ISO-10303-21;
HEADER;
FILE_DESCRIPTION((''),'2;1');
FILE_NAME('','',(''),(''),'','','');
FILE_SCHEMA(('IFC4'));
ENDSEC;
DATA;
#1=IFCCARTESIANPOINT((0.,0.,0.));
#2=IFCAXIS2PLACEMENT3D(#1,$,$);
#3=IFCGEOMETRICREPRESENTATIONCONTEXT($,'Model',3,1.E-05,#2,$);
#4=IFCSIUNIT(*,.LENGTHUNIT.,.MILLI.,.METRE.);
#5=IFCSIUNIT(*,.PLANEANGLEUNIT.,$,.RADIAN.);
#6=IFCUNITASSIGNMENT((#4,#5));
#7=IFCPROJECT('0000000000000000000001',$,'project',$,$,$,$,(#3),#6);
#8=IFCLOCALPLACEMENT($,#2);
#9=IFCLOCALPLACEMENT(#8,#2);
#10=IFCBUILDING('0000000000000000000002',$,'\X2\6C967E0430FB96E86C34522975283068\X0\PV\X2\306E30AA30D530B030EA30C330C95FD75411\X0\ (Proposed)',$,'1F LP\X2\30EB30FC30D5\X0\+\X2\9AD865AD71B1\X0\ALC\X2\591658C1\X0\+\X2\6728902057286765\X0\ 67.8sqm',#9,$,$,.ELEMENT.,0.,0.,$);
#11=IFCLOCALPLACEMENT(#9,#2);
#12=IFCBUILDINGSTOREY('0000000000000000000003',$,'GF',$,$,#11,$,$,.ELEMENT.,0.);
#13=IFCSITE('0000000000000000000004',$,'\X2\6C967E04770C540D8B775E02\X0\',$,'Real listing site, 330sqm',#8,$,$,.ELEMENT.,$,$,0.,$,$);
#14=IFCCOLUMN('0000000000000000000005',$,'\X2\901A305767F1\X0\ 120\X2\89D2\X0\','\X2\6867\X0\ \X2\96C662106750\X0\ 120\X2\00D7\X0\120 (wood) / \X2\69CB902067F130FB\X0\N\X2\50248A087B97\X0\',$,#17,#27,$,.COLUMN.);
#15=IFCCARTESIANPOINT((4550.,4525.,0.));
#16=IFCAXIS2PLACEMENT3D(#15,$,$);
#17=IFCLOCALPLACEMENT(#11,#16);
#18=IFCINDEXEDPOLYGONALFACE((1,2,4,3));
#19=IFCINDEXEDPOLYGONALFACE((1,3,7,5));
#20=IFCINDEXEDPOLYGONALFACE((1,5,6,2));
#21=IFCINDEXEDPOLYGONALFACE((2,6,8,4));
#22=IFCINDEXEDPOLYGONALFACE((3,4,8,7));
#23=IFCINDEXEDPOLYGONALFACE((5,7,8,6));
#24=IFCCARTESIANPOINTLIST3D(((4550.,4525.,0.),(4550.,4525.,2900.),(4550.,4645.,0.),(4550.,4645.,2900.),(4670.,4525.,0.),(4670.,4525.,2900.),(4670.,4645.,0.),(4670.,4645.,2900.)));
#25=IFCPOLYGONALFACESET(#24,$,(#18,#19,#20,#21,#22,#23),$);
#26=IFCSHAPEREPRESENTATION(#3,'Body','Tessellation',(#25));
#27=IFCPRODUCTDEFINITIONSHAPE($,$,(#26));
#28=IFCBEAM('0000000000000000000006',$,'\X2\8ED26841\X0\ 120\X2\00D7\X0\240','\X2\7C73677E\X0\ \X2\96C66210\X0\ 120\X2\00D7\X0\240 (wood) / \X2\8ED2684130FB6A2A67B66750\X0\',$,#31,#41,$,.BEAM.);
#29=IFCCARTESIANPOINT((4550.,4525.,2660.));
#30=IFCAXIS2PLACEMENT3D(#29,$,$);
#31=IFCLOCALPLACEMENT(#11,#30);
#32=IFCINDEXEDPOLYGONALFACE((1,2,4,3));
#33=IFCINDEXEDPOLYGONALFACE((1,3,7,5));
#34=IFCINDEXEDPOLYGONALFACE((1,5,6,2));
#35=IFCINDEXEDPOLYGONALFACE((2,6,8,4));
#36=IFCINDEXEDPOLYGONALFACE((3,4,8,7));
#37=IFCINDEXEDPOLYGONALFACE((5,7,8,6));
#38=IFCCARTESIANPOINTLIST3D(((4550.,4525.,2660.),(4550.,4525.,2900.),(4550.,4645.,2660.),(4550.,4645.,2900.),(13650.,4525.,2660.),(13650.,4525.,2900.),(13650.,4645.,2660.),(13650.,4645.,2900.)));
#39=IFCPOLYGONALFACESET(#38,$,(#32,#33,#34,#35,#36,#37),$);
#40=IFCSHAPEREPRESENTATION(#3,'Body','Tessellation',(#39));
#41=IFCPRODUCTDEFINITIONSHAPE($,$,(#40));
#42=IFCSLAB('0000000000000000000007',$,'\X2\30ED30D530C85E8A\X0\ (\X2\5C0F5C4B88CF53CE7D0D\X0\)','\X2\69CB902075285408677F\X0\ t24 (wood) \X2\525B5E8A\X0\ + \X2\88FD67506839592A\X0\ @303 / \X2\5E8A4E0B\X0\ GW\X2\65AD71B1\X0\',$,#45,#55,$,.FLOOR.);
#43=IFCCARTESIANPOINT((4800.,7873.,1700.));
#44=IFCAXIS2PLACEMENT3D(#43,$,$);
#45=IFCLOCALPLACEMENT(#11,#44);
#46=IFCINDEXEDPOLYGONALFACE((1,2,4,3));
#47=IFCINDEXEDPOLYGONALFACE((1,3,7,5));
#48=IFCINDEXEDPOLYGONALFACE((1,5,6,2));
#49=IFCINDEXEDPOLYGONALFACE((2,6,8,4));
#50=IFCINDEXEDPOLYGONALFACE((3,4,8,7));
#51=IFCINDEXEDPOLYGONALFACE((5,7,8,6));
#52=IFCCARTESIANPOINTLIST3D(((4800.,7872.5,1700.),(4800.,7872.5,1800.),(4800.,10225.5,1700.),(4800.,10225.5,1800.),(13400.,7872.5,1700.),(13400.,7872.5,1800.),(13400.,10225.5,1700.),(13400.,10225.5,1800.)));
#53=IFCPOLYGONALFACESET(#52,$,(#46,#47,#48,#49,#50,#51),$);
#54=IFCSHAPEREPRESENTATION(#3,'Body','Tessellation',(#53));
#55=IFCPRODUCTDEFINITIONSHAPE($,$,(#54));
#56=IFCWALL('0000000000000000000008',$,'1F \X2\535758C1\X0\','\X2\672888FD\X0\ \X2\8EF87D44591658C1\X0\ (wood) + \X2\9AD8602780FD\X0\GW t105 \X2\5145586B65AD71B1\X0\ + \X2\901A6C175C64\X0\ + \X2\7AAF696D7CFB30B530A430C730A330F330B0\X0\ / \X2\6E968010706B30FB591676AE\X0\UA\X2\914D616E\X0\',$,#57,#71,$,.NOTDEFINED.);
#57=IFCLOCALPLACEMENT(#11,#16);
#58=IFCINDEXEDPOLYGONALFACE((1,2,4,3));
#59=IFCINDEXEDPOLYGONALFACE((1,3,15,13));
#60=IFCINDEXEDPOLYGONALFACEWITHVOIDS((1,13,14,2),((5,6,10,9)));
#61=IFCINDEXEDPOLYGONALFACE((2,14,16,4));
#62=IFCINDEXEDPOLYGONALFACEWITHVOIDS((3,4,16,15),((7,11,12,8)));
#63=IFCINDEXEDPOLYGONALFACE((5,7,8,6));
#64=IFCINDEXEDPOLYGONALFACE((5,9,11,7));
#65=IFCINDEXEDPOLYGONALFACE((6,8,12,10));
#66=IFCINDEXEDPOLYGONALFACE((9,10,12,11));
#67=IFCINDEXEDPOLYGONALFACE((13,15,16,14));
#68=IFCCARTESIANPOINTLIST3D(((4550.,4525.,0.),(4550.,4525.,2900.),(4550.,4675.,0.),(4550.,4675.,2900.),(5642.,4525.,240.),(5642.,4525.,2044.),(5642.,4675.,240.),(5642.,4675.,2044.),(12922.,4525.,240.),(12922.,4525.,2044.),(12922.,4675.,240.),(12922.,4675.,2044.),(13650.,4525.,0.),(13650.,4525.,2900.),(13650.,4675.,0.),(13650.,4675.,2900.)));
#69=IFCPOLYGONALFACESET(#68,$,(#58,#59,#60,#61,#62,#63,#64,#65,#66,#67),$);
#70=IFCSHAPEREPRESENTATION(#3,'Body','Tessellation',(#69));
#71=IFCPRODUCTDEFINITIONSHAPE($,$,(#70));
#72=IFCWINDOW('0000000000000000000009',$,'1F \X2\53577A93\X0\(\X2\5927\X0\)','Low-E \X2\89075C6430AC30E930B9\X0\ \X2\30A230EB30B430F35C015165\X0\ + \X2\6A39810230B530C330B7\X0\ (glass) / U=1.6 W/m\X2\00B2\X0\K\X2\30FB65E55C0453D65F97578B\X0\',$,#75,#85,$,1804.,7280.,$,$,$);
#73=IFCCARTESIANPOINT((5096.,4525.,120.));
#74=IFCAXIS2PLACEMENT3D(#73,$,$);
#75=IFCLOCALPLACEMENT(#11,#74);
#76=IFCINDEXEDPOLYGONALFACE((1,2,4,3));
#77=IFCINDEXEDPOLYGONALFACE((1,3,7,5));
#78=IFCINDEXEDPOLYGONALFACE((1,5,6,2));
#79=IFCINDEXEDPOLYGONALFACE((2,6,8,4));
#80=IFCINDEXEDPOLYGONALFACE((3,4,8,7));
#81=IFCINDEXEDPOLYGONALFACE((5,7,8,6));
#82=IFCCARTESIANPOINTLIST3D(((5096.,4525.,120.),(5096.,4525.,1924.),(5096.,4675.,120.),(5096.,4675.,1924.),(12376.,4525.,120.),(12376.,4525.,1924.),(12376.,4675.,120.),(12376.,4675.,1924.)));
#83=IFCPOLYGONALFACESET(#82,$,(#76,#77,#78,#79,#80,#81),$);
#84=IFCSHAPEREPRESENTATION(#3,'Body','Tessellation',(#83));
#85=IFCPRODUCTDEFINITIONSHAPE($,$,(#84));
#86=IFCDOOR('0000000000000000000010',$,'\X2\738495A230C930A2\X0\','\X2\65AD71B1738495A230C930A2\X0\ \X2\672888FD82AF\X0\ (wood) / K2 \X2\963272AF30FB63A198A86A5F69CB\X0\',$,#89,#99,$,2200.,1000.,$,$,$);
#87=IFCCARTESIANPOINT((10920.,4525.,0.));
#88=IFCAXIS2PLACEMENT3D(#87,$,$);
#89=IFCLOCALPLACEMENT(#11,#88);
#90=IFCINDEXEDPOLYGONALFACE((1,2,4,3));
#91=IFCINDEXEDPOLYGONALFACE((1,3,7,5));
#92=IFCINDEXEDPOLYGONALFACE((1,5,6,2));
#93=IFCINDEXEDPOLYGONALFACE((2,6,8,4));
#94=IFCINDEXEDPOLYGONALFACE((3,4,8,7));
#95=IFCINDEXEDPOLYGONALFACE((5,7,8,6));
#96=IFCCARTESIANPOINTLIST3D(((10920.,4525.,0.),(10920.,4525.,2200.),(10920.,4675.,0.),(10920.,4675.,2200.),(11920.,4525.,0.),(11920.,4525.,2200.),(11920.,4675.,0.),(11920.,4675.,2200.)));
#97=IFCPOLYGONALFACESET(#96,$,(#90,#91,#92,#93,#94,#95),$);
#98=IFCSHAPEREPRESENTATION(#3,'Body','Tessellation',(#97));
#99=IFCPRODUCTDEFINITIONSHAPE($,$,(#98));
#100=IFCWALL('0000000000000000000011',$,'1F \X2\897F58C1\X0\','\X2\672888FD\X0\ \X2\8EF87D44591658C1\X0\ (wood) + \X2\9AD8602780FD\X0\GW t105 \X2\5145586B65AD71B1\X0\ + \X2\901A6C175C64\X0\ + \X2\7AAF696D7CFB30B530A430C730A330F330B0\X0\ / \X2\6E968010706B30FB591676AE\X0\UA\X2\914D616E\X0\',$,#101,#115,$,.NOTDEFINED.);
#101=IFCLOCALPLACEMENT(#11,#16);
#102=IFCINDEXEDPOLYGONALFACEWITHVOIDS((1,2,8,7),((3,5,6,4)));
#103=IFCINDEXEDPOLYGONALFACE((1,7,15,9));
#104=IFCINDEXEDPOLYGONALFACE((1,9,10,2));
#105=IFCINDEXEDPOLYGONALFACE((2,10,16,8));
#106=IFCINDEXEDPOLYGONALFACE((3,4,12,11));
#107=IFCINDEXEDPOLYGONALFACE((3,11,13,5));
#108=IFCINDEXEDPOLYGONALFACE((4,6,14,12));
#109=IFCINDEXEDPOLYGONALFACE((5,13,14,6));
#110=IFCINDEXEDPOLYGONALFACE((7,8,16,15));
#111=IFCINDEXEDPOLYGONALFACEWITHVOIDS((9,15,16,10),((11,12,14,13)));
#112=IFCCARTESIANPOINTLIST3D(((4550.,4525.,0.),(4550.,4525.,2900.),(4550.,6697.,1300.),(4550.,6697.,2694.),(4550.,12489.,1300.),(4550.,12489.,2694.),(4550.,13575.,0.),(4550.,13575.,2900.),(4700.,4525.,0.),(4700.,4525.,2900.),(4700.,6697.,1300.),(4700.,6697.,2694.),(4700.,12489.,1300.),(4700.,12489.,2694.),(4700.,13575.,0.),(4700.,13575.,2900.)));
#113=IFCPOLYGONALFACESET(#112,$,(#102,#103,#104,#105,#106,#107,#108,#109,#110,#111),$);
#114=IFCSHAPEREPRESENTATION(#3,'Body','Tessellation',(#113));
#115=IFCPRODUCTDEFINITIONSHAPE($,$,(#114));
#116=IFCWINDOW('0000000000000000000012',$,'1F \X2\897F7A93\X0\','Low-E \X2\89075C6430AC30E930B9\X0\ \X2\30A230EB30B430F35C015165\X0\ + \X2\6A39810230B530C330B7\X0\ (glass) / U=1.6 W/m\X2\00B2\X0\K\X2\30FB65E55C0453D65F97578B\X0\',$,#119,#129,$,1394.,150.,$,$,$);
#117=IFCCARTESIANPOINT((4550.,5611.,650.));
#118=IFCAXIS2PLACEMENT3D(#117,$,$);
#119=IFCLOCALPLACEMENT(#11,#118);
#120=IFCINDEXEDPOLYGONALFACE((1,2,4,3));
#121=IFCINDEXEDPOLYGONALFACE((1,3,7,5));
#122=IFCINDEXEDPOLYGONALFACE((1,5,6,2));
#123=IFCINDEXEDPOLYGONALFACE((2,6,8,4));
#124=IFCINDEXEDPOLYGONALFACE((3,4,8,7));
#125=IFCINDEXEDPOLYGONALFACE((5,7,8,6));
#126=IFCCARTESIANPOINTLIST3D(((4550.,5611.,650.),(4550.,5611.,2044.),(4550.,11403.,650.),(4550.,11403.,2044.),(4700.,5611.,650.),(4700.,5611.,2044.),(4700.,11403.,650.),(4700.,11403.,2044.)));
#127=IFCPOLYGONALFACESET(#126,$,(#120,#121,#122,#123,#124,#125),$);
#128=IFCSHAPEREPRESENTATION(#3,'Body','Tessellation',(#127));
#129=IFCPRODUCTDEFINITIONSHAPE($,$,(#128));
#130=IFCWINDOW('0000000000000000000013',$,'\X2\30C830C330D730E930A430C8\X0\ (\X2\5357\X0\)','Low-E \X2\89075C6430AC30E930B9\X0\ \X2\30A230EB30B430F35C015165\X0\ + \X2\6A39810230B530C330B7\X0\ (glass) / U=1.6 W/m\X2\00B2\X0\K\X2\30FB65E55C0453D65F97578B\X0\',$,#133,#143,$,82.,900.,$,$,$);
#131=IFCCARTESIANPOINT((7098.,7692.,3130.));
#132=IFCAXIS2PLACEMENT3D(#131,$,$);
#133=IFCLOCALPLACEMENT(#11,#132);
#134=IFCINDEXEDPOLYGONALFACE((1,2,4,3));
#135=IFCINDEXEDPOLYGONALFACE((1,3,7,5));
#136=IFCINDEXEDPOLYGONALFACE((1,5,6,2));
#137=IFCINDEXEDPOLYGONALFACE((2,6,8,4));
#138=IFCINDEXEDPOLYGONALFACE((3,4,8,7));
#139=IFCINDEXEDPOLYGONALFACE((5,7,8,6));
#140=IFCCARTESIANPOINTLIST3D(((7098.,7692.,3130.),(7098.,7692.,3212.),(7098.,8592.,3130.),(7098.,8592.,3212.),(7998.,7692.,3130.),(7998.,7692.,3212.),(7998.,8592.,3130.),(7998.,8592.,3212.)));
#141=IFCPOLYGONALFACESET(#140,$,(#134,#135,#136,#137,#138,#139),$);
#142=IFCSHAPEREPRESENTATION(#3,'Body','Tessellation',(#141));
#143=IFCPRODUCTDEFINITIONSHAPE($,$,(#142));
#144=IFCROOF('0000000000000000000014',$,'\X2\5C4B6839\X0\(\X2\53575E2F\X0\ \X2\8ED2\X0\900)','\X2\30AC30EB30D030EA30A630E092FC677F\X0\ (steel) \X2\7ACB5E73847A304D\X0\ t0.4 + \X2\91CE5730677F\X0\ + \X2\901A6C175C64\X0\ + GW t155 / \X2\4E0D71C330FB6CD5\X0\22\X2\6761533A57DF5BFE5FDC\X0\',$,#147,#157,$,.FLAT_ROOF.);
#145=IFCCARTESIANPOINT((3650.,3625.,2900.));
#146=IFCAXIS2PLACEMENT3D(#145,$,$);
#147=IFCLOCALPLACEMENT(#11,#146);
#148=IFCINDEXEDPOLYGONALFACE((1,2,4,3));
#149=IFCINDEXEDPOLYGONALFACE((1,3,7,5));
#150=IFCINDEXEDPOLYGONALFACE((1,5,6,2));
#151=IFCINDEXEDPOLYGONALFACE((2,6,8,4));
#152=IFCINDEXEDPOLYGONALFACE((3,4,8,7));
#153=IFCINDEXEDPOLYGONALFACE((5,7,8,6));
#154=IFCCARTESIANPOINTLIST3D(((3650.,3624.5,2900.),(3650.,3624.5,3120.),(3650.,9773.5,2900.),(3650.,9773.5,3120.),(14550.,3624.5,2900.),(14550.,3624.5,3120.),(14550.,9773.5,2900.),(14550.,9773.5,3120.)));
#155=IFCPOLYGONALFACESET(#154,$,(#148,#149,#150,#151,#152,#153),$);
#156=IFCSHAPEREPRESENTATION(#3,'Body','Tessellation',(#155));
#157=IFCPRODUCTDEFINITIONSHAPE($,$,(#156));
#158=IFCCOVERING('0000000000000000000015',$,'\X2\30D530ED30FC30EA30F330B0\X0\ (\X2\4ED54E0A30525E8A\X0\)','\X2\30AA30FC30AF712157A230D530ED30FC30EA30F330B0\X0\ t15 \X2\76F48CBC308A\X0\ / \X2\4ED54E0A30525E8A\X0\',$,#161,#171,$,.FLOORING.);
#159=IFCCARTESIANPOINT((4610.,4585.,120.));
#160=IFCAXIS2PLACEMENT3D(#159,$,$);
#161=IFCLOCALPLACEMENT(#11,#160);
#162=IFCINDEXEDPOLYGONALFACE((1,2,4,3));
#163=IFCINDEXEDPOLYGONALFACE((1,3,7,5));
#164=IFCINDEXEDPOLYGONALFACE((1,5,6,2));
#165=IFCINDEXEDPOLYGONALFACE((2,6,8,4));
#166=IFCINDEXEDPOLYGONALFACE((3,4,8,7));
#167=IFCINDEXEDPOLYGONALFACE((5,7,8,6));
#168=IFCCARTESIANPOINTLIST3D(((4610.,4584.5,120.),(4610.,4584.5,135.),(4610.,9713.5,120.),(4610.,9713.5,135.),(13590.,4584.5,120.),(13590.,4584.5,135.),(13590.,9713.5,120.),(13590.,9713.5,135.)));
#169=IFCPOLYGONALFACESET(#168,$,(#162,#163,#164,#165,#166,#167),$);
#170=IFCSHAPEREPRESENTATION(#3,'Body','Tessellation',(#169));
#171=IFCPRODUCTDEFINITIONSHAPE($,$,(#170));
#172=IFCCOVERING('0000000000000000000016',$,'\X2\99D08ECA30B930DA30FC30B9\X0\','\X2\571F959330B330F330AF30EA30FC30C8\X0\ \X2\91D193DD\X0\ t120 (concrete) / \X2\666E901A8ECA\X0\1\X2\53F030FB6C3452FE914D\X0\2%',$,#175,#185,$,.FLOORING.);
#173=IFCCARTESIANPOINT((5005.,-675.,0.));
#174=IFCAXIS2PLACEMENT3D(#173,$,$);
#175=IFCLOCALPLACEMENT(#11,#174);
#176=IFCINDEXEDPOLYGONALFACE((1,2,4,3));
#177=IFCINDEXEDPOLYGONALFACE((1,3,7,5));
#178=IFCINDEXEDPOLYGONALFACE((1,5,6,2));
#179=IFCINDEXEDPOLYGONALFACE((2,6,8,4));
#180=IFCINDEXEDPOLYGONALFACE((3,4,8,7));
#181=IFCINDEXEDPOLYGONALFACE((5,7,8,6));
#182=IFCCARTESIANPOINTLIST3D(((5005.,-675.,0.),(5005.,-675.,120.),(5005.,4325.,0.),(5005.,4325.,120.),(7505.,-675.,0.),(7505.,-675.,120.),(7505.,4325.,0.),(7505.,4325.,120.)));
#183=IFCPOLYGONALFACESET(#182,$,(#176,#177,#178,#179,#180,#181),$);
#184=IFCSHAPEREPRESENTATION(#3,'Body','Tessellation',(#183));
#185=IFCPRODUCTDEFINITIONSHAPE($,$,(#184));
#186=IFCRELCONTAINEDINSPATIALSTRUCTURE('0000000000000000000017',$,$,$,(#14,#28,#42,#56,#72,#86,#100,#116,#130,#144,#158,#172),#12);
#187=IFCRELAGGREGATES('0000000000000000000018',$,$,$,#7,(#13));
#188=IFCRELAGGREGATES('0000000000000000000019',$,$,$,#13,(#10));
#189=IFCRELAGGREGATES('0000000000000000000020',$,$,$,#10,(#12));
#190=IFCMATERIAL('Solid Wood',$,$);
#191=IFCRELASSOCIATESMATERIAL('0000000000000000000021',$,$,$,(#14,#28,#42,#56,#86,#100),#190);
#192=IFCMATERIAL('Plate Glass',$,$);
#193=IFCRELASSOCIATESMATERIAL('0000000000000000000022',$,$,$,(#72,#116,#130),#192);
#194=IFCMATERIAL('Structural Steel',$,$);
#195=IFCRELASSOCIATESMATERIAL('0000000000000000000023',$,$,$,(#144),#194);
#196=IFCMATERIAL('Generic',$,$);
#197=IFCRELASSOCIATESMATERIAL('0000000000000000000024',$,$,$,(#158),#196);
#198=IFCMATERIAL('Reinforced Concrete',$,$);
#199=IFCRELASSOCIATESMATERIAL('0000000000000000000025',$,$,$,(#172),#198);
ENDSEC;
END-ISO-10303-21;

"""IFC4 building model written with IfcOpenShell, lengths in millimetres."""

from ifc_helpers import new_model, si_unit, frame, frame_2d, origin, place, context, project, spatial, rectangle, extrude, material, element, fill, save


model = new_model("IFC4")

# Units and contexts
model_context = context("Model", 3, precision=1e-05, world=origin())
ifc_project = project(units=[si_unit("LENGTHUNIT", "METRE", prefix="MILLI"), si_unit("PLANEANGLEUNIT", "RADIAN")], contexts=[model_context])

# Site, building, storey
site_placement = place(None, origin())
site = spatial("IfcSite", under=ifc_project, at=site_placement, Name="沖縄県名護市", ObjectType="Real listing site, 330sqm", CompositionType="ELEMENT", RefElevation=0.0)
building_placement = place(site_placement, origin())
building = spatial("IfcBuilding", under=site, at=building_placement, Name="沖縄・雨水利用とPVのオフグリッド志向 (Proposed)", ObjectType="1F LPルーフ+高断熱ALC外壁+木造在来 67.8sqm", CompositionType="ELEMENT", ElevationOfRefHeight=0.0, ElevationOfTerrain=0.0)
storey_placement = place(building_placement, origin())
storey = spatial("IfcBuildingStorey", under=building, at=storey_placement, Name="GF", CompositionType="ELEMENT", Elevation=0.0)

# Column
ifc_material_1 = material(Name="Solid Wood")
column_1_placement = place(storey_placement, frame((4550.0, 4525.0, 0.0)))
element("IfcColumn", 1, at=column_1_placement, inside=storey, material=ifc_material_1, Name="通し柱 120角", Description="桧 集成材 120×120 (wood) / 構造柱・N値計算", PredefinedType="COLUMN", context=model_context, shape_type="SweptSolid", body=[
    extrude(rectangle(XDim=120.0, YDim=120.0, at=frame_2d((60.0, 60.0))), frame((4550.0, 4525.0, 0.0)), (0.0, 0.0, 1.0), 2900.0),
])

# Beam
beam_1_placement = place(storey_placement, frame((4550.0, 4525.0, 2660.0)))
element("IfcBeam", 2, at=beam_1_placement, inside=storey, material=ifc_material_1, Name="軒桁 120×240", Description="米松 集成 120×240 (wood) / 軒桁・横架材", PredefinedType="BEAM", context=model_context, shape_type="SweptSolid", body=[
    extrude(rectangle(XDim=9100.0, YDim=120.0, at=frame_2d((4550.0, 60.0))), frame((4550.0, 4525.0, 2660.0)), (0.0, 0.0, 1.0), 240.0),
])

# Slab
ifc_material_2 = material(Name="Reinforced Concrete")
slab_1_placement = place(storey_placement, frame((4800.0, 7873.0, 1700.0)))
element("IfcSlab", 3, at=slab_1_placement, inside=storey, material=ifc_material_1, Name="ロフト床 (小屋裏収納)", Description="構造用合板 t24 (wood) 剛床 + 製材根太 @303 / 床下 GW断熱", PredefinedType="FLOOR", context=model_context, shape_type="SweptSolid", body=[
    extrude(rectangle(XDim=8600.0, YDim=2353.0, at=frame_2d((4300.0, 1176.0))), frame((4800.0, 7873.0, 1700.0)), (0.0, 0.0, 1.0), 100.0),
])

# Wall, openings, window, door
wall_1_placement = place(storey_placement, frame((4550.0, 4525.0, 0.0)))
wall_1 = element("IfcWall", 4, at=wall_1_placement, inside=storey, material=ifc_material_1, Name="1F 南壁", Description="木製 軸組外壁 (wood) + 高性能GW t105 充填断熱 + 通気層 + 窯業系サイディング / 準耐火・外皮UA配慮", PredefinedType="NOTDEFINED", context=model_context, shape_type="SweptSolid", body=[
    extrude(rectangle(XDim=9100.0, YDim=150.0, at=frame_2d((4550.0, 75.0))), frame((4550.0, 4525.0, 0.0)), (0.0, 0.0, 1.0), 2900.0),
])
opening_1_placement = place(storey_placement, frame((5096.0, 4525.0, 120.0)))
opening_1 = element("IfcOpeningElement", 5, at=opening_1_placement, cuts=wall_1, PredefinedType="NOTDEFINED", context=model_context, shape_type="SweptSolid", body=[
    extrude(rectangle(XDim=7280.0, YDim=150.0, at=frame_2d((3640.0, 75.0))), frame((5096.0, 4525.0, 120.0)), (0.0, 0.0, 1.0), 1804.0),
])
opening_2_placement = place(storey_placement, frame((10920.0, 4525.0, 0.0)))
opening_2 = element("IfcOpeningElement", 6, at=opening_2_placement, cuts=wall_1, PredefinedType="NOTDEFINED", context=model_context, shape_type="SweptSolid", body=[
    extrude(rectangle(XDim=1000.0, YDim=150.0, at=frame_2d((500.0, 75.0))), frame((10920.0, 4525.0, 0.0)), (0.0, 0.0, 1.0), 2200.0),
])
ifc_material_3 = material(Name="Plate Glass")
window_1_placement = place(storey_placement, frame((5096.0, 4525.0, 120.0)))
window_1 = element("IfcWindow", 7, at=window_1_placement, inside=storey, material=ifc_material_3, Name="1F 南窓(大)", Description="Low-E 複層ガラス アルゴン封入 + 樹脂サッシ (glass) / U=1.6 W/m²K・日射取得型", OverallHeight=1804.0, OverallWidth=7280.0, context=model_context, shape_type="SweptSolid", body=[
    extrude(rectangle(XDim=7280.0, YDim=150.0, at=frame_2d((3640.0, 75.0))), frame((5096.0, 4525.0, 120.0)), (0.0, 0.0, 1.0), 1804.0),
])
fill(opening_1, window_1)
door_placement = place(storey_placement, frame((10920.0, 4525.0, 0.0)))
door = element("IfcDoor", 8, at=door_placement, inside=storey, material=ifc_material_1, Name="玄関ドア", Description="断熱玄関ドア 木製芯 (wood) / K2 防犯・採風機構", OverallHeight=2200.0, OverallWidth=1000.0, context=model_context, shape_type="SweptSolid", body=[
    extrude(rectangle(XDim=1000.0, YDim=150.0, at=frame_2d((500.0, 75.0))), frame((10920.0, 4525.0, 0.0)), (0.0, 0.0, 1.0), 2200.0),
])
fill(opening_2, door)

# Wall, opening, window
wall_2_placement = place(storey_placement, frame((4550.0, 4525.0, 0.0)))
wall_2 = element("IfcWall", 9, at=wall_2_placement, inside=storey, material=ifc_material_1, Name="1F 西壁", Description="木製 軸組外壁 (wood) + 高性能GW t105 充填断熱 + 通気層 + 窯業系サイディング / 準耐火・外皮UA配慮", PredefinedType="NOTDEFINED", context=model_context, shape_type="SweptSolid", body=[
    extrude(rectangle(XDim=150.0, YDim=9050.0, at=frame_2d((75.0, 4525.0))), frame((4550.0, 4525.0, 0.0)), (0.0, 0.0, 1.0), 2900.0),
])
opening_3_placement = place(storey_placement, frame((4550.0, 5611.0, 650.0)))
opening_3 = element("IfcOpeningElement", 10, at=opening_3_placement, cuts=wall_2, PredefinedType="NOTDEFINED", context=model_context, shape_type="SweptSolid", body=[
    extrude(rectangle(XDim=150.0, YDim=5792.0, at=frame_2d((75.0, 2896.0))), frame((4550.0, 5611.0, 650.0)), (0.0, 0.0, 1.0), 1394.0),
])
window_2_placement = place(storey_placement, frame((4550.0, 5611.0, 650.0)))
window_2 = element("IfcWindow", 11, at=window_2_placement, inside=storey, material=ifc_material_3, Name="1F 西窓", Description="Low-E 複層ガラス アルゴン封入 + 樹脂サッシ (glass) / U=1.6 W/m²K・日射取得型", OverallHeight=1394.0, OverallWidth=150.0, context=model_context, shape_type="SweptSolid", body=[
    extrude(rectangle(XDim=150.0, YDim=5792.0, at=frame_2d((75.0, 2896.0))), frame((4550.0, 5611.0, 650.0)), (0.0, 0.0, 1.0), 1394.0),
])
fill(opening_3, window_2)

# Window
window_3_placement = place(storey_placement, frame((7098.0, 7692.0, 3130.0)))
element("IfcWindow", 12, at=window_3_placement, inside=storey, material=ifc_material_3, Name="トップライト (南)", Description="Low-E 複層ガラス アルゴン封入 + 樹脂サッシ (glass) / U=1.6 W/m²K・日射取得型", OverallHeight=82.0, OverallWidth=900.0, context=model_context, shape_type="SweptSolid", body=[
    extrude(rectangle(XDim=900.0, YDim=900.0, at=frame_2d((450.0, 450.0))), frame((7098.0, 7692.0, 3130.0)), (0.0, 0.0, 1.0), 82.0),
])

# Roof
ifc_material_4 = material(Name="Structural Steel")
roof_placement = place(storey_placement, frame((3650.0, 3625.0, 2900.0)))
element("IfcRoof", 13, at=roof_placement, inside=storey, material=ifc_material_4, Name="屋根(南帯 軒900)", Description="ガルバリウム鋼板 (steel) 立平葺き t0.4 + 野地板 + 通気層 + GW t155 / 不燃・法22条区域対応", PredefinedType="FLAT_ROOF", context=model_context, shape_type="SweptSolid", body=[
    extrude(rectangle(XDim=10900.0, YDim=6149.0, at=frame_2d((5450.0, 3074.0))), frame((3650.0, 3625.0, 2900.0)), (0.0, 0.0, 1.0), 220.0),
])

# Coverings
ifc_material_5 = material(Name="Generic")
covering_1_placement = place(storey_placement, frame((4610.0, 4585.0, 120.0)))
element("IfcCovering", 14, at=covering_1_placement, inside=storey, material=ifc_material_5, Name="フローリング (仕上げ床)", Description="オーク無垢フローリング t15 直貼り / 仕上げ床", PredefinedType="FLOORING", context=model_context, shape_type="SweptSolid", body=[
    extrude(rectangle(XDim=8980.0, YDim=5129.0, at=frame_2d((4490.0, 2564.0))), frame((4610.0, 4585.0, 120.0)), (0.0, 0.0, 1.0), 15.0),
])
covering_2_placement = place(storey_placement, frame((5005.0, -675.0, 0.0)))
element("IfcCovering", 15, at=covering_2_placement, inside=storey, material=ifc_material_2, Name="駐車スペース", Description="土間コンクリート 金鏝 t120 (concrete) / 普通車1台・水勾配2%", PredefinedType="FLOORING", context=model_context, shape_type="SweptSolid", body=[
    extrude(rectangle(XDim=2500.0, YDim=5000.0, at=frame_2d((1250.0, 2500.0))), frame((5005.0, -675.0, 0.0)), (0.0, 0.0, 1.0), 120.0),
])

save(model, "model.ifc")
